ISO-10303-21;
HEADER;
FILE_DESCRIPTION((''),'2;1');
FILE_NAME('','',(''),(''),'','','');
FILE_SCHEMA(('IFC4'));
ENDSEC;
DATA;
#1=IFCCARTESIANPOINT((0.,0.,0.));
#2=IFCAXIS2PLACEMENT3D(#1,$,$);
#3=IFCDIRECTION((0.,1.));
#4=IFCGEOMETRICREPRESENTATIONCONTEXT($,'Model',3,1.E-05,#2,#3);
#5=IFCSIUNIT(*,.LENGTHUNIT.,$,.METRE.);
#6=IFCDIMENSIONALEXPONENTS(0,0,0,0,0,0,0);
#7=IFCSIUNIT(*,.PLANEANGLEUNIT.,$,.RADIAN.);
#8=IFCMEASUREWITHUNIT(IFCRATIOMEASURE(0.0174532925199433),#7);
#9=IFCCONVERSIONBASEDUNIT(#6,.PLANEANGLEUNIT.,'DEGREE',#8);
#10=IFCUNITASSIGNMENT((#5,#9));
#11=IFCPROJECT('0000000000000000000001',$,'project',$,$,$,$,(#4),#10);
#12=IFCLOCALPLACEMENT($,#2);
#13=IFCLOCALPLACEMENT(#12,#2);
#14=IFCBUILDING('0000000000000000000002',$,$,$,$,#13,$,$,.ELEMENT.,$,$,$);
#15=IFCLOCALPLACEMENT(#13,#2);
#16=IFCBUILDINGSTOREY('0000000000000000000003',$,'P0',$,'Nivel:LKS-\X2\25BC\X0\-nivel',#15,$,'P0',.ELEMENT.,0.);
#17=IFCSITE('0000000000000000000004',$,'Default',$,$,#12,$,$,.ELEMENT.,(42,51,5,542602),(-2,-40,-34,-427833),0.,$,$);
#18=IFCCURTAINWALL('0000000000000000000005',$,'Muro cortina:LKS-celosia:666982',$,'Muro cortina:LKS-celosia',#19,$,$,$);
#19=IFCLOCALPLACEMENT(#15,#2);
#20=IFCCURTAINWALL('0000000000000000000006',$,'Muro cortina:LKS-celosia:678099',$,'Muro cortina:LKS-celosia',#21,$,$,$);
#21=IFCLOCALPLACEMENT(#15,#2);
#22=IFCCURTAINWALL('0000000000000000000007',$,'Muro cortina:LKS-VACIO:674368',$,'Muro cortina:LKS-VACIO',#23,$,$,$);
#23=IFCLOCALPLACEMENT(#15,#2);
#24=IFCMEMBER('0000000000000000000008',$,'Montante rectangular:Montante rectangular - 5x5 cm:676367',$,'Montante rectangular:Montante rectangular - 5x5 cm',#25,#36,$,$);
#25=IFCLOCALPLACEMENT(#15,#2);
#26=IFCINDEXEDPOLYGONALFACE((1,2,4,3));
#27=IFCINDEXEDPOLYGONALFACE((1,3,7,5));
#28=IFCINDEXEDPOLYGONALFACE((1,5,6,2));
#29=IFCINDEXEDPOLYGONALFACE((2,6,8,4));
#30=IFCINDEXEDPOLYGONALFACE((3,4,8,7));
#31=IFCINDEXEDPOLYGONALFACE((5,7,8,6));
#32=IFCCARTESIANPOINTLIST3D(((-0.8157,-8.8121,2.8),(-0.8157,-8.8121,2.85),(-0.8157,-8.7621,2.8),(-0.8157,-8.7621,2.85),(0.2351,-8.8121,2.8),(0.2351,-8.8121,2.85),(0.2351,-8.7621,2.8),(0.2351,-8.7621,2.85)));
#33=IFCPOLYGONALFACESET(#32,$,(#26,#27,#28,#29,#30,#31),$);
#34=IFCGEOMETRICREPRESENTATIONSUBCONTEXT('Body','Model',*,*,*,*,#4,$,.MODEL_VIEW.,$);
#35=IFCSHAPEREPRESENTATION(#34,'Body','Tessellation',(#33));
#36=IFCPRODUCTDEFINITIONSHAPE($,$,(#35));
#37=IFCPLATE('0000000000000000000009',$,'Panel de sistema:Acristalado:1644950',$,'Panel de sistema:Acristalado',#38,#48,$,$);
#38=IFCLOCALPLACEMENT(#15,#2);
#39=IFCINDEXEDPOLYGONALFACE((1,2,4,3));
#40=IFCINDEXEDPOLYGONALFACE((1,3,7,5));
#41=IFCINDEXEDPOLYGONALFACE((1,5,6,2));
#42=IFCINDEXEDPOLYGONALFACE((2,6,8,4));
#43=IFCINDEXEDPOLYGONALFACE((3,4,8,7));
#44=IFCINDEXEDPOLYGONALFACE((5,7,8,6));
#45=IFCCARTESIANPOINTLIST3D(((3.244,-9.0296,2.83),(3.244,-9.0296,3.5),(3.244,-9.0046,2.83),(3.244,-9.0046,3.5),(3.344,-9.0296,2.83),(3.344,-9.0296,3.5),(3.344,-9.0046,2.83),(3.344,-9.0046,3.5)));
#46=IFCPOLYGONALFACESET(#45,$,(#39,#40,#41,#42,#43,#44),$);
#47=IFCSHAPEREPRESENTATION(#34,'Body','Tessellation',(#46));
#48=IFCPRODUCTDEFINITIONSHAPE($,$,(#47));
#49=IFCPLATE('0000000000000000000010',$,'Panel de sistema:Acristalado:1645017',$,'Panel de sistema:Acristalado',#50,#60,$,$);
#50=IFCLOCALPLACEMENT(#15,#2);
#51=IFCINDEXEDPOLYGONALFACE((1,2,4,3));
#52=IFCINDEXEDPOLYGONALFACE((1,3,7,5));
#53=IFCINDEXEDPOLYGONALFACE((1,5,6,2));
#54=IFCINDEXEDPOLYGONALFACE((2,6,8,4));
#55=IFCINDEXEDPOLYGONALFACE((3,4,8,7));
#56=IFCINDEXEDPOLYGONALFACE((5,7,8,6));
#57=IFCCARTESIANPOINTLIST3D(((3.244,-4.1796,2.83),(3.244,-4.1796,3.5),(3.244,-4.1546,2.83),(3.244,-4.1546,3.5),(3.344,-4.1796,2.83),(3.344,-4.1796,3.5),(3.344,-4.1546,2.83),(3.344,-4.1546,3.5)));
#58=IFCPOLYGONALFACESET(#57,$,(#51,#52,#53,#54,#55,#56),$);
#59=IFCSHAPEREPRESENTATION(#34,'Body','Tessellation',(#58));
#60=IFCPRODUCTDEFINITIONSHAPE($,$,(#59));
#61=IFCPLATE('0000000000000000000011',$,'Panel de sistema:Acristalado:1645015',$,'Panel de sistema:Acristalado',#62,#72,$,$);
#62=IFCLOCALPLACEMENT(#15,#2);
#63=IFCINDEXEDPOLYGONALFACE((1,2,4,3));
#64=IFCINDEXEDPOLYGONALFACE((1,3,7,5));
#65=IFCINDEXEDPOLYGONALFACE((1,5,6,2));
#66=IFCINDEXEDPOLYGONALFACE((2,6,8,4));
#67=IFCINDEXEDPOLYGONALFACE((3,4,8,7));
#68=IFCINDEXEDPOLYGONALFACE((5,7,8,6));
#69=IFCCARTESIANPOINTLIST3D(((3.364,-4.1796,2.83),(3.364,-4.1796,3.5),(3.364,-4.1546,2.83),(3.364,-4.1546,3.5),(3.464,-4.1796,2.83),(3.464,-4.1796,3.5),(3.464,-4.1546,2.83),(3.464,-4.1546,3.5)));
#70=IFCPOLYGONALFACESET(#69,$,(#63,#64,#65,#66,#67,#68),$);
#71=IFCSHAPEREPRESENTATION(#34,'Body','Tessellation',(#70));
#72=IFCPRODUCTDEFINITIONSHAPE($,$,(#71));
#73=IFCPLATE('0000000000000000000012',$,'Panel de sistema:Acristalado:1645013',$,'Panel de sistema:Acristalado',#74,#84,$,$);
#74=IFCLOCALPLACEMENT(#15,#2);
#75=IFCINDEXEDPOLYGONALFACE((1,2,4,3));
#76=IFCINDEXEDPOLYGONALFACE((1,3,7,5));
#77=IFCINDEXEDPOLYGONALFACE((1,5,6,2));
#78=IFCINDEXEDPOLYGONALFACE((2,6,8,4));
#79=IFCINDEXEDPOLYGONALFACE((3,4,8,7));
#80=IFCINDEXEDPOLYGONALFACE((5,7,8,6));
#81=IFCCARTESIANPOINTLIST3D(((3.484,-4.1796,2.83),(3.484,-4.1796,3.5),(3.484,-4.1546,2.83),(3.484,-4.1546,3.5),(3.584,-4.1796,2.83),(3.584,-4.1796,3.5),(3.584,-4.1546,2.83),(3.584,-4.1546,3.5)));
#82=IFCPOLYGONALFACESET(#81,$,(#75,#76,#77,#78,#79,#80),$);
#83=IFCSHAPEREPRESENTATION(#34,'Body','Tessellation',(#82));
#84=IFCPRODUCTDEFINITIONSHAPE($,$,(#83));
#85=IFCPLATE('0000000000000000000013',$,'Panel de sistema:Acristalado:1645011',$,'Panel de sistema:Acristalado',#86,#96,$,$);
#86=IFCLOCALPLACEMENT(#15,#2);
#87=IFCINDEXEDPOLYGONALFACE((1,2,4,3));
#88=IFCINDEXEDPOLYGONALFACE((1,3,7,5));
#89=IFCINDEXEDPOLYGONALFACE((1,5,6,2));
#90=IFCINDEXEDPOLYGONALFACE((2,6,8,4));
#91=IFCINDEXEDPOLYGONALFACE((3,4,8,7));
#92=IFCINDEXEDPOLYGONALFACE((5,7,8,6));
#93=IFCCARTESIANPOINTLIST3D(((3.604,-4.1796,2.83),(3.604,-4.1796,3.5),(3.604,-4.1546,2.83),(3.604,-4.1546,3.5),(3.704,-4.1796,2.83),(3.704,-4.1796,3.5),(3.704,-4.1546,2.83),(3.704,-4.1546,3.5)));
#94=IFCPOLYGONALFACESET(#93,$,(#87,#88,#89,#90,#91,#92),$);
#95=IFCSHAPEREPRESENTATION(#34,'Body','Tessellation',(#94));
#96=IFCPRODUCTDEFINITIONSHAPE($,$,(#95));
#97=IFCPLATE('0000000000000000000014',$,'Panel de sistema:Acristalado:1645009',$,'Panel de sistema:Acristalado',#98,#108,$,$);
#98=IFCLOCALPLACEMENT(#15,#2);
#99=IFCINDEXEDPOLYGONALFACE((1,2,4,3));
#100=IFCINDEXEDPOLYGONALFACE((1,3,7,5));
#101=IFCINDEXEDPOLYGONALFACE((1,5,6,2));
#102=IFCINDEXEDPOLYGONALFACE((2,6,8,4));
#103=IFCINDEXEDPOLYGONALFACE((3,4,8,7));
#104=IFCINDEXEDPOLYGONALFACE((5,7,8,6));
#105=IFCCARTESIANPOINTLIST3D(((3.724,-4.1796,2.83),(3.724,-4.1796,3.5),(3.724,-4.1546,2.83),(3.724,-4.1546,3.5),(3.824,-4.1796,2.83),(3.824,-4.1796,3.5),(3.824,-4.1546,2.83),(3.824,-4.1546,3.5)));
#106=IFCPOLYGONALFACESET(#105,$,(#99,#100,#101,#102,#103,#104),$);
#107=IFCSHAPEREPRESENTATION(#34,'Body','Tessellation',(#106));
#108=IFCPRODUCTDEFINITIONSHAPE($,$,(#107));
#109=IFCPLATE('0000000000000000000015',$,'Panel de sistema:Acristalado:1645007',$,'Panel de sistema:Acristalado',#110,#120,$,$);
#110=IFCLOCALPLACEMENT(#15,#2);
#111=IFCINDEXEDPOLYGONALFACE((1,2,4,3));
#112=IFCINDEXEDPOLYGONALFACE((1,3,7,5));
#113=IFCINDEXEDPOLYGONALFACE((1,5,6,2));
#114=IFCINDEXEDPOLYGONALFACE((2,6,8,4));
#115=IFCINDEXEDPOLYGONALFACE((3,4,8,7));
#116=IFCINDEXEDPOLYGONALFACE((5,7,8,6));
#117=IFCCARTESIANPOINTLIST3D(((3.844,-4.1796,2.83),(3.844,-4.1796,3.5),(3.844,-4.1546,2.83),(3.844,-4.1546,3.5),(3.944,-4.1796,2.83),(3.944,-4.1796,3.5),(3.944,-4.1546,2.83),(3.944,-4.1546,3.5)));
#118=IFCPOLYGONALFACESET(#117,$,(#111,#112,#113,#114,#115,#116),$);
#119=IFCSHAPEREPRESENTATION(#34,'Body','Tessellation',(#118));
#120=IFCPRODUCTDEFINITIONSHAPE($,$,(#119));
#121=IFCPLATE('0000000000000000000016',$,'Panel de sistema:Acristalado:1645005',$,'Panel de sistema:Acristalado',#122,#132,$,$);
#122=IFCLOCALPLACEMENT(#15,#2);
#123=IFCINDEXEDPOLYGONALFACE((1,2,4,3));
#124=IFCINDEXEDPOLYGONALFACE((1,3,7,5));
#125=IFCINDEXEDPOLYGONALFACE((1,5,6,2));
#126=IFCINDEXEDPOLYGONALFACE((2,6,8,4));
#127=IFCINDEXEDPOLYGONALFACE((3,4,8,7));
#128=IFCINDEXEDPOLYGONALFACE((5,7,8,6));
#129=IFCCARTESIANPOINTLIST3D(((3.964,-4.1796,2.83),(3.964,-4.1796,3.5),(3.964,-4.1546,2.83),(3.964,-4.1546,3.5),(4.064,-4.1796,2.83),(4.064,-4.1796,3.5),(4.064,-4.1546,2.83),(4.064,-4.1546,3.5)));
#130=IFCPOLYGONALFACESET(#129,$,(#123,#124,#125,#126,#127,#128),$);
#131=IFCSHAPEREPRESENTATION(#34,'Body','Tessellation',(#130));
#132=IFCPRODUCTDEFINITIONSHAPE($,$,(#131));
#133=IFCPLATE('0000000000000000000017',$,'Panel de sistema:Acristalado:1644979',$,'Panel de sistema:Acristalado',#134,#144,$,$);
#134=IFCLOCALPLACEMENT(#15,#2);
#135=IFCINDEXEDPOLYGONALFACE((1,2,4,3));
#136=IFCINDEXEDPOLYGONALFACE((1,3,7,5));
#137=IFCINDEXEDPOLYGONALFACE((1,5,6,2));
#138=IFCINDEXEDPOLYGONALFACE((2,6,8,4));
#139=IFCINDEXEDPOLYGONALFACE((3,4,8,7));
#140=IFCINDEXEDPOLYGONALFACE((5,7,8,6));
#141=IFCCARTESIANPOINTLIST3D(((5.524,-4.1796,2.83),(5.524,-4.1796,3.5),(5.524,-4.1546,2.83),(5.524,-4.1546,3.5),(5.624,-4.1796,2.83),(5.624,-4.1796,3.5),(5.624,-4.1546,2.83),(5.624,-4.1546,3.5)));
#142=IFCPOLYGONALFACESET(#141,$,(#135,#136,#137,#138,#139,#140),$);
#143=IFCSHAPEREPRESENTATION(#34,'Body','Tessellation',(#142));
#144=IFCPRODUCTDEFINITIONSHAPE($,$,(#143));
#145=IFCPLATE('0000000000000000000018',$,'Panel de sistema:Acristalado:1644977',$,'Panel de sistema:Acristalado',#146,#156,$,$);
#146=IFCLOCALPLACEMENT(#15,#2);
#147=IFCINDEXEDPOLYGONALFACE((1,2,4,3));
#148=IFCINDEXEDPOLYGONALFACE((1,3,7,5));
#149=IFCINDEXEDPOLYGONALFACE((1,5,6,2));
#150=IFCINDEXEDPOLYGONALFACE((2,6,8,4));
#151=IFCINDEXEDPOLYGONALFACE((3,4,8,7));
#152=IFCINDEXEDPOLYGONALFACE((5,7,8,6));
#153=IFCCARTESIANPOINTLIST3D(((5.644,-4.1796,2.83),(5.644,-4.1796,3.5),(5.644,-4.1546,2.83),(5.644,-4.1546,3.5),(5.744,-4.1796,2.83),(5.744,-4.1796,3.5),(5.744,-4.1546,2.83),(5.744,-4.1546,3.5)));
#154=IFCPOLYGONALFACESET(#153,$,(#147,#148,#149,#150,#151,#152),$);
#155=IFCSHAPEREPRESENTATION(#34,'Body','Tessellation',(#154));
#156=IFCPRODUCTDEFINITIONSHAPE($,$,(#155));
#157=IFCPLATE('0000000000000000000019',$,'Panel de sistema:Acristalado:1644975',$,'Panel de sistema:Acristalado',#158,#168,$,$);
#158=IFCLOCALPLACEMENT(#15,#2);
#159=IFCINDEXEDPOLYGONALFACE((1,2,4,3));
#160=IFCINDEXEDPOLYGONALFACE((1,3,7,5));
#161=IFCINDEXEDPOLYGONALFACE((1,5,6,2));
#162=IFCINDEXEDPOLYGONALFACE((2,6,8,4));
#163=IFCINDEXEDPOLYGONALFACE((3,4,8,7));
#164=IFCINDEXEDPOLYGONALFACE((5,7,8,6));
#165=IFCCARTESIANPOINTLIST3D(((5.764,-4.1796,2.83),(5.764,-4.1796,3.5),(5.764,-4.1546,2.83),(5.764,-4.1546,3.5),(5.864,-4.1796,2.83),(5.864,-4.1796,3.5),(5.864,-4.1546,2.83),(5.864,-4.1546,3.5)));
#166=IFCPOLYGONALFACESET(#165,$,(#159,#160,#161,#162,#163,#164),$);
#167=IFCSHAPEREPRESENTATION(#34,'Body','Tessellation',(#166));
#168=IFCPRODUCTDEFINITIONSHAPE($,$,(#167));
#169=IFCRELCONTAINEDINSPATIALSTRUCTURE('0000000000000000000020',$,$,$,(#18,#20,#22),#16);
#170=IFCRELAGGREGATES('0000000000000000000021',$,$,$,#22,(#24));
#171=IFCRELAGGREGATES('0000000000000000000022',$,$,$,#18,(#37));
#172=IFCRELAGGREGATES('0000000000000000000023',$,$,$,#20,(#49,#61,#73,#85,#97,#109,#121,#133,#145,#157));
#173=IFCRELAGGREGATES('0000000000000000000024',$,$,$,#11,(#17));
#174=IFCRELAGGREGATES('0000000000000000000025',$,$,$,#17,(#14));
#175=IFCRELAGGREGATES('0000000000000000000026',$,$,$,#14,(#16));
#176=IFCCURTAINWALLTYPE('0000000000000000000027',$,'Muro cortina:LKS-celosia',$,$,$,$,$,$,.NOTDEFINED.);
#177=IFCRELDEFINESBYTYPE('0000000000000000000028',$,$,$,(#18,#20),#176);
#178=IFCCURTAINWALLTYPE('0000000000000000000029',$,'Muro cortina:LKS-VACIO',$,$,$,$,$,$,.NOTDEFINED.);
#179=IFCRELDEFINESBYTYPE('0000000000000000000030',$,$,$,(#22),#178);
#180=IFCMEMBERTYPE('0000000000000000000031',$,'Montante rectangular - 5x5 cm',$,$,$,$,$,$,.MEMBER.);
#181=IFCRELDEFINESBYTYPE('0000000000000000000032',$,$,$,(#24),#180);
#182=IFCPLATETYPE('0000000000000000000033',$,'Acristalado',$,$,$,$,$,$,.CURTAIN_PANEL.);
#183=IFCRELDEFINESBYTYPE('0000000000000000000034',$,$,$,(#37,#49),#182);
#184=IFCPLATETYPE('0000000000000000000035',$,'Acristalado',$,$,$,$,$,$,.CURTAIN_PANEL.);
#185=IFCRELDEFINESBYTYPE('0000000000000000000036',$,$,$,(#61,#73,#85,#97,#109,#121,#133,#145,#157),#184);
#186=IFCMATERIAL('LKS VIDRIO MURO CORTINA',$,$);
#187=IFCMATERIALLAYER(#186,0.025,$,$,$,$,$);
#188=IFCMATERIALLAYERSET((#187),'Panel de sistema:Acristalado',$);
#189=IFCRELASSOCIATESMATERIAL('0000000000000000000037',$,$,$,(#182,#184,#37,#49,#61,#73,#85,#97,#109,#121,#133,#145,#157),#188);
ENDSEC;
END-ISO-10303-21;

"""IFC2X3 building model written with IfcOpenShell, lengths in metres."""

from ifc_helpers import new_model, entity, si_unit, converted_unit, direction, frame, origin, origin_2d_with_axis, place, context, subcontext, project, spatial, rectangle, extrude, source, transform, mapped, material, layer, layer_set, layer_usage, type_object, type_shapes, element, aggregate, save


model = new_model("IFC2X3")

# Units and contexts
model_context = context("Model", 3, precision=1e-05, world=origin(), true_north=direction((0.0, 1.0)))
body_context = subcontext(model_context, "Body", "Model", "MODEL_VIEW")
ifc_project = project(units=[si_unit("LENGTHUNIT", "METRE"), converted_unit("PLANEANGLEUNIT", "DEGREE", entity("IfcRatioMeasure", 0.0174532925199433), si_unit("PLANEANGLEUNIT", "RADIAN"), dimensions=[0, 0, 0, 0, 0, 0, 0])], contexts=[model_context])

# Site, building, storey
site_placement = place(None, origin())
site = spatial("IfcSite", under=ifc_project, at=site_placement, Name="Default", CompositionType="ELEMENT", RefLatitude=(42, 51, 5, 542602), RefLongitude=(-2, -40, -34, -427833), RefElevation=0.0)
building_placement = place(site_placement, origin())
building = spatial("IfcBuilding", under=site, at=building_placement, CompositionType="ELEMENT")
storey_placement = place(building_placement, origin())
storey = spatial("IfcBuildingStorey", under=building, at=storey_placement, Name="P0", ObjectType="Nivel:LKS-▼-nivel", LongName="P0", CompositionType="ELEMENT", Elevation=0.0)

# Curtain walls
curtain_wall_type_1 = type_object("IfcCurtainWallType", Name="Muro cortina:LKS-VACIO", PredefinedType="NOTDEFINED")
curtain_wall_type_2 = type_object("IfcCurtainWallType", Name="Muro cortina:LKS-celosia", PredefinedType="NOTDEFINED")
curtain_wall_1_placement = place(storey_placement, origin())
curtain_wall_1 = element("IfcCurtainWall", 1, at=curtain_wall_1_placement, inside=storey, type_object=curtain_wall_type_2, Name="Muro cortina:LKS-celosia:666982", ObjectType="Muro cortina:LKS-celosia")
curtain_wall_2_placement = place(storey_placement, origin())
curtain_wall_2 = element("IfcCurtainWall", 2, at=curtain_wall_2_placement, inside=storey, type_object=curtain_wall_type_2, Name="Muro cortina:LKS-celosia:678099", ObjectType="Muro cortina:LKS-celosia")

# Curtain wall, member
curtain_wall_3_placement = place(storey_placement, origin())
curtain_wall_3 = element("IfcCurtainWall", 3, at=curtain_wall_3_placement, inside=storey, type_object=curtain_wall_type_1, Name="Muro cortina:LKS-VACIO:674368", ObjectType="Muro cortina:LKS-VACIO")
member_type_1 = type_object("IfcMemberType", Name="Montante rectangular - 5x5 cm", PredefinedType="MEMBER")
shared_shape_1 = source(origin(), body_context, "Body", "SweptSolid", [
    extrude(rectangle(XDim=0.05, YDim=0.05, at=origin_2d_with_axis()), frame((-0.025, -0.1, -1.0509), z_axis=(0.0, 0.0, 1.0), x_axis=(0.0, -1.0, 0.0)), (0.0, 0.0, 1.0), 1.0509),
])
type_shapes(member_type_1, [shared_shape_1])
member_1_placement = place(storey_placement, frame((0.2351, -8.8871, 2.85), z_axis=(1.0, 0.0, 0.0), x_axis=(0.0, 0.0, 1.0)))
member_1 = element("IfcMember", 4, at=member_1_placement, type_object=member_type_1, Name="Montante rectangular:Montante rectangular - 5x5 cm:676367", ObjectType="Montante rectangular:Montante rectangular - 5x5 cm", context=body_context, shape_type="MappedRepresentation", body=[
    mapped(shared_shape_1, transform((0.0, 0.0, 0.0), scale=1.0)),
])
aggregate(curtain_wall_3, [member_1])

# Plates
ifc_material = material(Name="LKS VIDRIO MURO CORTINA")
ifc_layer = layer(ifc_material, 0.025)
ifc_layer_set = layer_set([ifc_layer], Name="Panel de sistema:Acristalado")
ifc_layer_usage_1 = layer_usage(ifc_layer_set, "AXIS3", "POSITIVE", 0.0)
plate_type_1 = type_object("IfcPlateType", Name="Acristalado", PredefinedType="CURTAIN_PANEL", material=ifc_layer_set)
shared_shape_2 = source(origin(), body_context, "Body", "SweptSolid", [
    extrude(rectangle(XDim=0.025, YDim=0.1, at=origin_2d_with_axis()), frame((0.0, 0.0, 0.0), z_axis=(0.0, 0.0, 1.0), x_axis=(0.0, 1.0, 0.0)), (0.0, 0.0, 1.0), 0.67),
])
type_shapes(plate_type_1, [shared_shape_2])
plate_1_placement = place(curtain_wall_1_placement, frame((3.294, -9.0171, 2.83)))
plate_1 = element("IfcPlate", 5, at=plate_1_placement, type_object=plate_type_1, material=ifc_layer_usage_1, Name="Panel de sistema:Acristalado:1644950", ObjectType="Panel de sistema:Acristalado", context=body_context, shape_type="MappedRepresentation", body=[
    mapped(shared_shape_2, transform((0.0, 0.0, 0.0), scale=1.0)),
])
aggregate(curtain_wall_1, [plate_1])
ifc_layer_usage_2 = layer_usage(ifc_layer_set, "AXIS3", "POSITIVE", 0.0)
plate_2_placement = place(curtain_wall_2_placement, frame((3.294, -4.1671, 2.83)))
plate_2 = element("IfcPlate", 6, at=plate_2_placement, type_object=plate_type_1, material=ifc_layer_usage_2, Name="Panel de sistema:Acristalado:1645017", ObjectType="Panel de sistema:Acristalado", context=body_context, shape_type="MappedRepresentation", body=[
    mapped(shared_shape_2, transform((0.0, 0.0, 0.0), scale=1.0)),
])
ifc_layer_usage_3 = layer_usage(ifc_layer_set, "AXIS3", "POSITIVE", 0.0)
plate_type_2 = type_object("IfcPlateType", Name="Acristalado", PredefinedType="CURTAIN_PANEL", material=ifc_layer_set)
shared_shape_3 = source(origin(), body_context, "Body", "SweptSolid", [
    extrude(rectangle(XDim=0.025, YDim=0.1, at=origin_2d_with_axis()), frame((0.0, 0.0, 0.0), z_axis=(0.0, 0.0, 1.0), x_axis=(0.0, 1.0, 0.0)), (0.0, 0.0, 1.0), 0.67),
])
type_shapes(plate_type_2, [shared_shape_3])
plate_3_placement = place(curtain_wall_2_placement, frame((3.414, -4.1671, 2.83)))
plate_3 = element("IfcPlate", 7, at=plate_3_placement, type_object=plate_type_2, material=ifc_layer_usage_3, Name="Panel de sistema:Acristalado:1645015", ObjectType="Panel de sistema:Acristalado", context=body_context, shape_type="MappedRepresentation", body=[
    mapped(shared_shape_3, transform((0.0, 0.0, 0.0), scale=1.0)),
])
ifc_layer_usage_4 = layer_usage(ifc_layer_set, "AXIS3", "POSITIVE", 0.0)
plate_4_placement = place(curtain_wall_2_placement, frame((3.534, -4.1671, 2.83)))
plate_4 = element("IfcPlate", 8, at=plate_4_placement, type_object=plate_type_2, material=ifc_layer_usage_4, Name="Panel de sistema:Acristalado:1645013", ObjectType="Panel de sistema:Acristalado", context=body_context, shape_type="MappedRepresentation", body=[
    mapped(shared_shape_3, transform((0.0, 0.0, 0.0), scale=1.0)),
])
ifc_layer_usage_5 = layer_usage(ifc_layer_set, "AXIS3", "POSITIVE", 0.0)
plate_5_placement = place(curtain_wall_2_placement, frame((3.654, -4.1671, 2.83)))
plate_5 = element("IfcPlate", 9, at=plate_5_placement, type_object=plate_type_2, material=ifc_layer_usage_5, Name="Panel de sistema:Acristalado:1645011", ObjectType="Panel de sistema:Acristalado", context=body_context, shape_type="MappedRepresentation", body=[
    mapped(shared_shape_3, transform((0.0, 0.0, 0.0), scale=1.0)),
])
ifc_layer_usage_6 = layer_usage(ifc_layer_set, "AXIS3", "POSITIVE", 0.0)
plate_6_placement = place(curtain_wall_2_placement, frame((3.774, -4.1671, 2.83)))
plate_6 = element("IfcPlate", 10, at=plate_6_placement, type_object=plate_type_2, material=ifc_layer_usage_6, Name="Panel de sistema:Acristalado:1645009", ObjectType="Panel de sistema:Acristalado", context=body_context, shape_type="MappedRepresentation", body=[
    mapped(shared_shape_3, transform((0.0, 0.0, 0.0), scale=1.0)),
])
ifc_layer_usage_7 = layer_usage(ifc_layer_set, "AXIS3", "POSITIVE", 0.0)
plate_7_placement = place(curtain_wall_2_placement, frame((3.894, -4.1671, 2.83)))
plate_7 = element("IfcPlate", 11, at=plate_7_placement, type_object=plate_type_2, material=ifc_layer_usage_7, Name="Panel de sistema:Acristalado:1645007", ObjectType="Panel de sistema:Acristalado", context=body_context, shape_type="MappedRepresentation", body=[
    mapped(shared_shape_3, transform((0.0, 0.0, 0.0), scale=1.0)),
])
ifc_layer_usage_8 = layer_usage(ifc_layer_set, "AXIS3", "POSITIVE", 0.0)
plate_8_placement = place(curtain_wall_2_placement, frame((4.014, -4.1671, 2.83)))
plate_8 = element("IfcPlate", 12, at=plate_8_placement, type_object=plate_type_2, material=ifc_layer_usage_8, Name="Panel de sistema:Acristalado:1645005", ObjectType="Panel de sistema:Acristalado", context=body_context, shape_type="MappedRepresentation", body=[
    mapped(shared_shape_3, transform((0.0, 0.0, 0.0), scale=1.0)),
])
ifc_layer_usage_9 = layer_usage(ifc_layer_set, "AXIS3", "POSITIVE", 0.0)
plate_9_placement = place(curtain_wall_2_placement, frame((5.574, -4.1671, 2.83)))
plate_9 = element("IfcPlate", 13, at=plate_9_placement, type_object=plate_type_2, material=ifc_layer_usage_9, Name="Panel de sistema:Acristalado:1644979", ObjectType="Panel de sistema:Acristalado", context=body_context, shape_type="MappedRepresentation", body=[
    mapped(shared_shape_3, transform((0.0, 0.0, 0.0), scale=1.0)),
])
ifc_layer_usage_10 = layer_usage(ifc_layer_set, "AXIS3", "POSITIVE", 0.0)
plate_10_placement = place(curtain_wall_2_placement, frame((5.694, -4.1671, 2.83)))
plate_10 = element("IfcPlate", 14, at=plate_10_placement, type_object=plate_type_2, material=ifc_layer_usage_10, Name="Panel de sistema:Acristalado:1644977", ObjectType="Panel de sistema:Acristalado", context=body_context, shape_type="MappedRepresentation", body=[
    mapped(shared_shape_3, transform((0.0, 0.0, 0.0), scale=1.0)),
])
ifc_layer_usage_11 = layer_usage(ifc_layer_set, "AXIS3", "POSITIVE", 0.0)
plate_11_placement = place(curtain_wall_2_placement, frame((5.814, -4.1671, 2.83)))
plate_11 = element("IfcPlate", 15, at=plate_11_placement, type_object=plate_type_2, material=ifc_layer_usage_11, Name="Panel de sistema:Acristalado:1644975", ObjectType="Panel de sistema:Acristalado", context=body_context, shape_type="MappedRepresentation", body=[
    mapped(shared_shape_3, transform((0.0, 0.0, 0.0), scale=1.0)),
])
aggregate(curtain_wall_2, [plate_2, plate_3, plate_4, plate_5, plate_6, plate_7, plate_8, plate_9, plate_10, plate_11])

save(model, "model.ifc")
